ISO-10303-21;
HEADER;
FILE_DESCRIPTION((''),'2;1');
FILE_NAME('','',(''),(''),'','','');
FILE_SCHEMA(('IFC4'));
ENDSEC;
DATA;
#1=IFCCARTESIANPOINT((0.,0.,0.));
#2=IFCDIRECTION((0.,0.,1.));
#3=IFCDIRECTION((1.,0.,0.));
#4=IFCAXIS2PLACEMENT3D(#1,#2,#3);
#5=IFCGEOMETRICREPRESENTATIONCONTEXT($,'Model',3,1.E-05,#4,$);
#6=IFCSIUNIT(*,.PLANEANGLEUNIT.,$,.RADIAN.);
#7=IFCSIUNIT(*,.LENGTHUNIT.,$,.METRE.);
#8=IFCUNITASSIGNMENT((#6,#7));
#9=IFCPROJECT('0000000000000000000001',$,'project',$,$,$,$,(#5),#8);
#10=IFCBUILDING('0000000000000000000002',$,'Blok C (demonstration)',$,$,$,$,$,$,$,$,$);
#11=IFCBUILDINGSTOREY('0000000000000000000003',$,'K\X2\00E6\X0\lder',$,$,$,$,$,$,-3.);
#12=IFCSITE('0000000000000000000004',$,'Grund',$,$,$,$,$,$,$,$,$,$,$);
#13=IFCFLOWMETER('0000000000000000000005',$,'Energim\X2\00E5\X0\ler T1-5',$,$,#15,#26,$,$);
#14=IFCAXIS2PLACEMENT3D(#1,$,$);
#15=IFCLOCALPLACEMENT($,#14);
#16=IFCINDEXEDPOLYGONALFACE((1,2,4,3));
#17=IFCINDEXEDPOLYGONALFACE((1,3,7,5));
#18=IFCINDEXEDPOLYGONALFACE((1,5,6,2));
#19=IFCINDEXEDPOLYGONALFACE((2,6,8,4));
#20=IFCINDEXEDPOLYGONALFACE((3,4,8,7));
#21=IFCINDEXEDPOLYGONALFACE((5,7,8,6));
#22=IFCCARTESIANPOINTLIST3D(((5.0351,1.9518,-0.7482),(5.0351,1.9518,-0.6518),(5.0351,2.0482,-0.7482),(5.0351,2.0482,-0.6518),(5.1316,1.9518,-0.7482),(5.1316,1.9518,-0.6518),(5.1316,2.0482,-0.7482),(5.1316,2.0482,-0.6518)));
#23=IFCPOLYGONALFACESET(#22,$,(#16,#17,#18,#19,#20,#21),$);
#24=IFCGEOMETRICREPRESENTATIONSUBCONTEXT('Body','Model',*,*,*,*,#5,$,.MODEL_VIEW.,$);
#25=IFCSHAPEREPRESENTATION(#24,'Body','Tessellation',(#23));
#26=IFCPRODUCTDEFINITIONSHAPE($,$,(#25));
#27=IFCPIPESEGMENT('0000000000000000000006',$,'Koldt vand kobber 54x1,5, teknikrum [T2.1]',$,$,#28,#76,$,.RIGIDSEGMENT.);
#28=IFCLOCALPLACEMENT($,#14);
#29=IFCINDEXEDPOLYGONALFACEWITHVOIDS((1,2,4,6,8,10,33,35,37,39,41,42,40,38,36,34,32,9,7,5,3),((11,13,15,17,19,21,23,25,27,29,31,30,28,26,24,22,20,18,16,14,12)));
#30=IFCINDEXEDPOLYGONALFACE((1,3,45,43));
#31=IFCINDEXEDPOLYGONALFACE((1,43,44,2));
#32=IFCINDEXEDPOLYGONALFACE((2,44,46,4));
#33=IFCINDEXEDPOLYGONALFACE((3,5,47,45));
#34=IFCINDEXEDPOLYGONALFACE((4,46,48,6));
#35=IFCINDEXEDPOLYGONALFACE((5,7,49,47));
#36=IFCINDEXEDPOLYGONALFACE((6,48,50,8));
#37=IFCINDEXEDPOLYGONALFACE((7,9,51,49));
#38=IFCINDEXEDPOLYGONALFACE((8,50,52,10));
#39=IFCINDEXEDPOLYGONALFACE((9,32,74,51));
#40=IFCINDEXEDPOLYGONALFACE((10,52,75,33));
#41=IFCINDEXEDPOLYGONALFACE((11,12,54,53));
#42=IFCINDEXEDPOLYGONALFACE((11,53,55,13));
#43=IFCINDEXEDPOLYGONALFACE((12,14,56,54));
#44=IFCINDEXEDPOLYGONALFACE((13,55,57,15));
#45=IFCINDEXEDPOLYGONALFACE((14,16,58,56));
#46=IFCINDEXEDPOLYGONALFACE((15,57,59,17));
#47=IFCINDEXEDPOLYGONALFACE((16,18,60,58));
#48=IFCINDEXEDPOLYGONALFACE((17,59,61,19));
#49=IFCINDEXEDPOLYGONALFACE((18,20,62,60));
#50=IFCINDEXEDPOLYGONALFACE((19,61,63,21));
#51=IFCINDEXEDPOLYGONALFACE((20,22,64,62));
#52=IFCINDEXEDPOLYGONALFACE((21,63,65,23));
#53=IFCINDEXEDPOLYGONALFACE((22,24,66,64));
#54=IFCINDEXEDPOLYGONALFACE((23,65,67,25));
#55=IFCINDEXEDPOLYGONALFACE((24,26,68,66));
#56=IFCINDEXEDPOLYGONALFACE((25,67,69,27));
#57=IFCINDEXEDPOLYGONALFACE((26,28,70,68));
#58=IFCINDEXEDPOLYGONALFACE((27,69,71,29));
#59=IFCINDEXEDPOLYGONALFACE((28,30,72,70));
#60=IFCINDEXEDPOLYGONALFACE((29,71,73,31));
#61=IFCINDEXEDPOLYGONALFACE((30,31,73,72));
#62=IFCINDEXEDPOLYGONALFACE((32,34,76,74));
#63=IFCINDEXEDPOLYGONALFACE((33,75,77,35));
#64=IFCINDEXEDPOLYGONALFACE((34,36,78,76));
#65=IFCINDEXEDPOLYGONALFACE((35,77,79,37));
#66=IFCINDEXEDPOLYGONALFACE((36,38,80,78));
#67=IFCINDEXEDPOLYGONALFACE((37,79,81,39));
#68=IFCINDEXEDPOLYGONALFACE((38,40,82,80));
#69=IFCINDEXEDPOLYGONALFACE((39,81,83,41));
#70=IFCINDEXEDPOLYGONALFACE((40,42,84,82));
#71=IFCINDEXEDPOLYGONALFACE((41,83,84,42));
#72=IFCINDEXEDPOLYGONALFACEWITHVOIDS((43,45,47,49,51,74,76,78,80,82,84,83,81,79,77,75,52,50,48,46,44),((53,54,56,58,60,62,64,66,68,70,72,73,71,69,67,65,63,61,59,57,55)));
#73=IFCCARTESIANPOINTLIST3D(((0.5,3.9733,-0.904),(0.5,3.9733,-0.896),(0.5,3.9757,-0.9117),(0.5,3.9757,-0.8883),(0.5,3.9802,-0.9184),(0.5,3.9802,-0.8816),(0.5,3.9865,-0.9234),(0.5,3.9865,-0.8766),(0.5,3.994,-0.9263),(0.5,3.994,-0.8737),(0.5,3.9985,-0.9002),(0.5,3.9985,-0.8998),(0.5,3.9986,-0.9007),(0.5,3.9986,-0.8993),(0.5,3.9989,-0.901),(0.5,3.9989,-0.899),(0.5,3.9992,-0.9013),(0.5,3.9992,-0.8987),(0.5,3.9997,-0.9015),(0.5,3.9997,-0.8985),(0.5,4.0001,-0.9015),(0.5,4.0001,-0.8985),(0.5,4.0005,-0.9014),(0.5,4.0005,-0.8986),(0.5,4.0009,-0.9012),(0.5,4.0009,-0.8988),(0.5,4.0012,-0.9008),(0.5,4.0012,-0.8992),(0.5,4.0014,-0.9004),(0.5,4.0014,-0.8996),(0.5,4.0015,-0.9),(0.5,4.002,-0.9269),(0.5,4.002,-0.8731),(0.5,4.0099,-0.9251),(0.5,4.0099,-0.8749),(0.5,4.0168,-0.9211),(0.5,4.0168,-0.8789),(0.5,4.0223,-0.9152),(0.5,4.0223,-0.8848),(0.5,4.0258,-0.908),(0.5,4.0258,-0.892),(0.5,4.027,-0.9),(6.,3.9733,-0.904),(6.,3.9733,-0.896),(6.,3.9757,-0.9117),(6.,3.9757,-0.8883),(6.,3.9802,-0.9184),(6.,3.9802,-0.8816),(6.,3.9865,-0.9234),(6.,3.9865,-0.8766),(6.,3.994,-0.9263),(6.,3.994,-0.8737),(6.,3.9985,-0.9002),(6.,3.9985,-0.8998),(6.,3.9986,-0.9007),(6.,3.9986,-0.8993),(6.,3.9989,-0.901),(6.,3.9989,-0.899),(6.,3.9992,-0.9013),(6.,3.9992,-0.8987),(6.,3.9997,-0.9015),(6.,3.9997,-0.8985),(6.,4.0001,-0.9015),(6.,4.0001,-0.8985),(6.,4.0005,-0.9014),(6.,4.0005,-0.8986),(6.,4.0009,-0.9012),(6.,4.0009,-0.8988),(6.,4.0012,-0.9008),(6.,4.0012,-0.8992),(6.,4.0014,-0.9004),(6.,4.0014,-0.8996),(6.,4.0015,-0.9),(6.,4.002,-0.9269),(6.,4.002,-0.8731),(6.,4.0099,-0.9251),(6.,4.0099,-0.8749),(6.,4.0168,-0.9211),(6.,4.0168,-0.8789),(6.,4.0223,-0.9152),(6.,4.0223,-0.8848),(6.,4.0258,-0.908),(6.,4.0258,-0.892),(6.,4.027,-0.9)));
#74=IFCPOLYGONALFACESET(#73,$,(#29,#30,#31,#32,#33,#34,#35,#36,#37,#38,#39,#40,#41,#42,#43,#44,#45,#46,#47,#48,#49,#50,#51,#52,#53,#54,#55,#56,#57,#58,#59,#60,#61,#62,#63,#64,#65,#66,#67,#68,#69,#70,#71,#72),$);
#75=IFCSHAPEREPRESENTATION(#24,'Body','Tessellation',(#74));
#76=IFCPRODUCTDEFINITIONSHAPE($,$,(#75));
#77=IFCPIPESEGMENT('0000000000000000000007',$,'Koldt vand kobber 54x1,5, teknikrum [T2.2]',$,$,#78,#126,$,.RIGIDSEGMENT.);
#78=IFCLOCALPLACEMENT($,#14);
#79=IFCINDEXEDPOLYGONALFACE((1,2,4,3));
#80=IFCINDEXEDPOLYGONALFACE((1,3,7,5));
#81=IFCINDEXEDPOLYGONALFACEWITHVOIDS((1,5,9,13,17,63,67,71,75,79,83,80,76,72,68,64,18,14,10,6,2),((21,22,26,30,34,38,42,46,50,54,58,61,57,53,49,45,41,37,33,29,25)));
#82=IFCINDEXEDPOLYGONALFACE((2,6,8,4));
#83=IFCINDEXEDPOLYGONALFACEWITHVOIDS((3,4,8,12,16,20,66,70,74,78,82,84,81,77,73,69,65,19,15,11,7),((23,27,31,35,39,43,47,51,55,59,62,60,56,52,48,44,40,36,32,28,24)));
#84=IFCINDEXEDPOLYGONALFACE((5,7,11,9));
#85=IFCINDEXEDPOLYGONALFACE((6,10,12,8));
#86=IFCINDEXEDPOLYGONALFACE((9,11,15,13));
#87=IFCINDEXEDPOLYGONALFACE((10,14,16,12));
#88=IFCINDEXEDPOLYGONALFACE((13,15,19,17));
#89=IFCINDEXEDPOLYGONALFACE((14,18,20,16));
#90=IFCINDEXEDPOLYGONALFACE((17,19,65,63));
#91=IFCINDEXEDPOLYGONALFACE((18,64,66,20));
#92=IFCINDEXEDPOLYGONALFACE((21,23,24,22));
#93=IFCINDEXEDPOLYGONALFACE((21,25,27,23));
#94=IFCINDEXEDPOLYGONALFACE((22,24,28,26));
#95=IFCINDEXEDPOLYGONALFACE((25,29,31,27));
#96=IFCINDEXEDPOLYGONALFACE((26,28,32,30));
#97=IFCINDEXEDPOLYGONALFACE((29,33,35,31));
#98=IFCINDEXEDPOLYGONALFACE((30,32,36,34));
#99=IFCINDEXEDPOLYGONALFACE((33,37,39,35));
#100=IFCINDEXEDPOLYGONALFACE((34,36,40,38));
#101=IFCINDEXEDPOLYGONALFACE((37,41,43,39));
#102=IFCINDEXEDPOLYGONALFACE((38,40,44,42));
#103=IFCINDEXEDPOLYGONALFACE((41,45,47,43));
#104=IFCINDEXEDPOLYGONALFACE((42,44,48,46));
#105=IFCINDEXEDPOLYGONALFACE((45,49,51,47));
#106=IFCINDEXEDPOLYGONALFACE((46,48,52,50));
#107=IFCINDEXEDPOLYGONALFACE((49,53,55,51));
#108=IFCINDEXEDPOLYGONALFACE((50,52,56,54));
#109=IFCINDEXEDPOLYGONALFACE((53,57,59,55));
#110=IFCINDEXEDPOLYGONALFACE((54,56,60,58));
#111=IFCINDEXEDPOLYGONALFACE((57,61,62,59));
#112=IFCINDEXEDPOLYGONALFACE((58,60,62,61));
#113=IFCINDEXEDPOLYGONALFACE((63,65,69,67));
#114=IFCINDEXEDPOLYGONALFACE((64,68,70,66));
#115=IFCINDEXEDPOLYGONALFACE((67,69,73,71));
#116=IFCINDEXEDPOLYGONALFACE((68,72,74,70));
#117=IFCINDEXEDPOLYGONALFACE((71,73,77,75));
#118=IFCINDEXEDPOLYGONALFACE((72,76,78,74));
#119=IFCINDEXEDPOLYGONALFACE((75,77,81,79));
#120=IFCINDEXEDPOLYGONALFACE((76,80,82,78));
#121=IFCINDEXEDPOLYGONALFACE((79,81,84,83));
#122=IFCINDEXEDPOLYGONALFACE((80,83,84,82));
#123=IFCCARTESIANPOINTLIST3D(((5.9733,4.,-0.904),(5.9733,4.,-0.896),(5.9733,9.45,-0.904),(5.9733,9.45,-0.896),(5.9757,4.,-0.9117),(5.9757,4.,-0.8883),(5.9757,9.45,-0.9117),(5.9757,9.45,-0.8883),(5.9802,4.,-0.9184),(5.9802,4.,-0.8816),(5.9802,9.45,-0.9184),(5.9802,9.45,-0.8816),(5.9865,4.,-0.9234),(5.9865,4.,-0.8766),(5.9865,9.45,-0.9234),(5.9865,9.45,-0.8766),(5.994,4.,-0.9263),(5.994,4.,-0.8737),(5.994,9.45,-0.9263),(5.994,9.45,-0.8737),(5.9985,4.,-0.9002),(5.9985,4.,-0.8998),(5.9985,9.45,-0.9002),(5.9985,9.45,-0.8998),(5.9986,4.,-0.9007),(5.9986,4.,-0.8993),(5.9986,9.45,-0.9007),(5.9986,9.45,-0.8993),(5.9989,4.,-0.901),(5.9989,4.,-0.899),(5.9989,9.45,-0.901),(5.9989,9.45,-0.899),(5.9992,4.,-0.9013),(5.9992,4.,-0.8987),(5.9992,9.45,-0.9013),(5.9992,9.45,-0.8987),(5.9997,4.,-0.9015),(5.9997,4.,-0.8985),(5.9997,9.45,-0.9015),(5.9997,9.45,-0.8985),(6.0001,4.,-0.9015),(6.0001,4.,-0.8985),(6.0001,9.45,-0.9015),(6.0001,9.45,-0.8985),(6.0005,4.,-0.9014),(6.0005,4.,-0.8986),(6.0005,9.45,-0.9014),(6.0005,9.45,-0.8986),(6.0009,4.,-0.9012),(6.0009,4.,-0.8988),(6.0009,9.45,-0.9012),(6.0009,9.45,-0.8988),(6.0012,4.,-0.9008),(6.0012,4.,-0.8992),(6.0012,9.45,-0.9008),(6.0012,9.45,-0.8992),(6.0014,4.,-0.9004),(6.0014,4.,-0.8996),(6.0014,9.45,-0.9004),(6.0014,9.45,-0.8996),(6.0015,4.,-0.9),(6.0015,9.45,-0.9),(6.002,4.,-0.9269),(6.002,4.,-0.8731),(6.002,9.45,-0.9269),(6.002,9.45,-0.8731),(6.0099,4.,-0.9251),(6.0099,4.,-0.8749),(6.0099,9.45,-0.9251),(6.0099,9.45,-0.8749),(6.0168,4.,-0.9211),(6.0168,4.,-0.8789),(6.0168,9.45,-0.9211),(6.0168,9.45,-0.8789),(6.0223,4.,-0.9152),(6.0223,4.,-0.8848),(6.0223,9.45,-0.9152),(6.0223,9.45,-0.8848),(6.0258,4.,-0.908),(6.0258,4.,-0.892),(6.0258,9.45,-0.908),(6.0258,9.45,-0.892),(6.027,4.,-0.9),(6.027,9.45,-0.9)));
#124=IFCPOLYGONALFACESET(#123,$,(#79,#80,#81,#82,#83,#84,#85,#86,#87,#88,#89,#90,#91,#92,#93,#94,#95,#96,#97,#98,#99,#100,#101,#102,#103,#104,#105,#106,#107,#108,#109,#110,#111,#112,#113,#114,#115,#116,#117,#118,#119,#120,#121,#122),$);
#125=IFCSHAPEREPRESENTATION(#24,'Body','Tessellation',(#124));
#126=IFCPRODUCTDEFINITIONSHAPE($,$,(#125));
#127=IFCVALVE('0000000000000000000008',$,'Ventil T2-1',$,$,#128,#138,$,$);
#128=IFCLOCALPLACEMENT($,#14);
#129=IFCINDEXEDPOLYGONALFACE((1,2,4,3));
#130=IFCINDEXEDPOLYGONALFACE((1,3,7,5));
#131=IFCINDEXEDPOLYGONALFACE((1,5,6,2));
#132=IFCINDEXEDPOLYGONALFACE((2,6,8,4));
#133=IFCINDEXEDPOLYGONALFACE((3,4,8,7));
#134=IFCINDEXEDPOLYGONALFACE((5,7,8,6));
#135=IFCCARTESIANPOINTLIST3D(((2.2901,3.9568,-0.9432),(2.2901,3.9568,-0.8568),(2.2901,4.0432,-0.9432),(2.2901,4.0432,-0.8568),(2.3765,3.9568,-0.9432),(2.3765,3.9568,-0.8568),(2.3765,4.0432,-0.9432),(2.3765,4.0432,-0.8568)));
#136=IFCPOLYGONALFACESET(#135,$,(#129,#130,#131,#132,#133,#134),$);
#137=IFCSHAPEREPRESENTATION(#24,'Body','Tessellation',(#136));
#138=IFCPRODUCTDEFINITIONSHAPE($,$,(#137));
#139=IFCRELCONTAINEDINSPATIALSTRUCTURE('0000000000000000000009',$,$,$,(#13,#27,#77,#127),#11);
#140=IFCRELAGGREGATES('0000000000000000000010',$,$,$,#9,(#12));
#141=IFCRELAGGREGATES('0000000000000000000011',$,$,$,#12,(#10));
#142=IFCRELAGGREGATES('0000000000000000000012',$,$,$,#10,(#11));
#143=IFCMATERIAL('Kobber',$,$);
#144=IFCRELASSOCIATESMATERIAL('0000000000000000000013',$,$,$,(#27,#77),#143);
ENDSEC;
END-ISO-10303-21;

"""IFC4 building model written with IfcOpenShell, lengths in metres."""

from ifc_helpers import new_model, si_unit, frame, origin_with_axes, place, context, subcontext, project, spatial, polyline, hollow_circle, outline, extrude, material, element, save


model = new_model("IFC4")

# Units and contexts
model_context = context("Model", 3, precision=1e-05, world=origin_with_axes())
body_context = subcontext(model_context, "Body", "Model", "MODEL_VIEW")
ifc_project = project(units=[si_unit("PLANEANGLEUNIT", "RADIAN"), si_unit("LENGTHUNIT", "METRE")], contexts=[model_context])

# Site, building, storey
site = spatial("IfcSite", under=ifc_project, Name="Grund")
building = spatial("IfcBuilding", under=site, Name="Blok C (demonstration)")
storey = spatial("IfcBuildingStorey", under=building, Name="Kælder", Elevation=-3.0)

# Shared definitions
ifc_material_1 = material(Name="Kobber")

# Flow meter
flow_meter_placement = place(None, origin_with_axes())
element("IfcFlowMeter", 1, at=flow_meter_placement, inside=storey, Name="Energimåler T1-5", context=body_context, shape_type="SweptSolid", body=[
    extrude(outline(polyline([(5.0351, 1.9518), (5.1316, 1.9518), (5.1316, 2.0482), (5.0351, 2.0482), (5.0351, 1.9518)])), frame((0.0, 0.0, -0.7482)), (0.0, 0.0, 1.0), 0.0965),
])

# Pipe segments
pipe_segment_1_placement = place(None, origin_with_axes())
element("IfcPipeSegment", 2, at=pipe_segment_1_placement, inside=storey, material=ifc_material_1, Name="Koldt vand kobber 54x1,5, teknikrum [T2.1]", PredefinedType="RIGIDSEGMENT", context=body_context, shape_type="SweptSolid", body=[
    extrude(hollow_circle(Radius=0.027, WallThickness=0.0255), frame((0.5, 4.0, -0.9), z_axis=(1.0, 0.0, 0.0), x_axis=(0.0, 1.0, 0.0)), (0.0, 0.0, 1.0), 5.5),
])
pipe_segment_2_placement = place(None, origin_with_axes())
element("IfcPipeSegment", 3, at=pipe_segment_2_placement, inside=storey, material=ifc_material_1, Name="Koldt vand kobber 54x1,5, teknikrum [T2.2]", PredefinedType="RIGIDSEGMENT", context=body_context, shape_type="SweptSolid", body=[
    extrude(hollow_circle(Radius=0.027, WallThickness=0.0255), frame((6.0, 4.0, -0.9), z_axis=(0.0, 1.0, 0.0), x_axis=(1.0, 0.0, 0.0)), (0.0, 0.0, 1.0), 5.45),
])

# Valve
valve_1_placement = place(None, origin_with_axes())
element("IfcValve", 4, at=valve_1_placement, inside=storey, Name="Ventil T2-1", context=body_context, shape_type="SweptSolid", body=[
    extrude(outline(polyline([(2.2901, 3.9568), (2.3765, 3.9568), (2.3765, 4.0432), (2.2901, 4.0432), (2.2901, 3.9568)])), frame((0.0, 0.0, -0.9432)), (0.0, 0.0, 1.0), 0.0864),
])

save(model, "model.ifc")
